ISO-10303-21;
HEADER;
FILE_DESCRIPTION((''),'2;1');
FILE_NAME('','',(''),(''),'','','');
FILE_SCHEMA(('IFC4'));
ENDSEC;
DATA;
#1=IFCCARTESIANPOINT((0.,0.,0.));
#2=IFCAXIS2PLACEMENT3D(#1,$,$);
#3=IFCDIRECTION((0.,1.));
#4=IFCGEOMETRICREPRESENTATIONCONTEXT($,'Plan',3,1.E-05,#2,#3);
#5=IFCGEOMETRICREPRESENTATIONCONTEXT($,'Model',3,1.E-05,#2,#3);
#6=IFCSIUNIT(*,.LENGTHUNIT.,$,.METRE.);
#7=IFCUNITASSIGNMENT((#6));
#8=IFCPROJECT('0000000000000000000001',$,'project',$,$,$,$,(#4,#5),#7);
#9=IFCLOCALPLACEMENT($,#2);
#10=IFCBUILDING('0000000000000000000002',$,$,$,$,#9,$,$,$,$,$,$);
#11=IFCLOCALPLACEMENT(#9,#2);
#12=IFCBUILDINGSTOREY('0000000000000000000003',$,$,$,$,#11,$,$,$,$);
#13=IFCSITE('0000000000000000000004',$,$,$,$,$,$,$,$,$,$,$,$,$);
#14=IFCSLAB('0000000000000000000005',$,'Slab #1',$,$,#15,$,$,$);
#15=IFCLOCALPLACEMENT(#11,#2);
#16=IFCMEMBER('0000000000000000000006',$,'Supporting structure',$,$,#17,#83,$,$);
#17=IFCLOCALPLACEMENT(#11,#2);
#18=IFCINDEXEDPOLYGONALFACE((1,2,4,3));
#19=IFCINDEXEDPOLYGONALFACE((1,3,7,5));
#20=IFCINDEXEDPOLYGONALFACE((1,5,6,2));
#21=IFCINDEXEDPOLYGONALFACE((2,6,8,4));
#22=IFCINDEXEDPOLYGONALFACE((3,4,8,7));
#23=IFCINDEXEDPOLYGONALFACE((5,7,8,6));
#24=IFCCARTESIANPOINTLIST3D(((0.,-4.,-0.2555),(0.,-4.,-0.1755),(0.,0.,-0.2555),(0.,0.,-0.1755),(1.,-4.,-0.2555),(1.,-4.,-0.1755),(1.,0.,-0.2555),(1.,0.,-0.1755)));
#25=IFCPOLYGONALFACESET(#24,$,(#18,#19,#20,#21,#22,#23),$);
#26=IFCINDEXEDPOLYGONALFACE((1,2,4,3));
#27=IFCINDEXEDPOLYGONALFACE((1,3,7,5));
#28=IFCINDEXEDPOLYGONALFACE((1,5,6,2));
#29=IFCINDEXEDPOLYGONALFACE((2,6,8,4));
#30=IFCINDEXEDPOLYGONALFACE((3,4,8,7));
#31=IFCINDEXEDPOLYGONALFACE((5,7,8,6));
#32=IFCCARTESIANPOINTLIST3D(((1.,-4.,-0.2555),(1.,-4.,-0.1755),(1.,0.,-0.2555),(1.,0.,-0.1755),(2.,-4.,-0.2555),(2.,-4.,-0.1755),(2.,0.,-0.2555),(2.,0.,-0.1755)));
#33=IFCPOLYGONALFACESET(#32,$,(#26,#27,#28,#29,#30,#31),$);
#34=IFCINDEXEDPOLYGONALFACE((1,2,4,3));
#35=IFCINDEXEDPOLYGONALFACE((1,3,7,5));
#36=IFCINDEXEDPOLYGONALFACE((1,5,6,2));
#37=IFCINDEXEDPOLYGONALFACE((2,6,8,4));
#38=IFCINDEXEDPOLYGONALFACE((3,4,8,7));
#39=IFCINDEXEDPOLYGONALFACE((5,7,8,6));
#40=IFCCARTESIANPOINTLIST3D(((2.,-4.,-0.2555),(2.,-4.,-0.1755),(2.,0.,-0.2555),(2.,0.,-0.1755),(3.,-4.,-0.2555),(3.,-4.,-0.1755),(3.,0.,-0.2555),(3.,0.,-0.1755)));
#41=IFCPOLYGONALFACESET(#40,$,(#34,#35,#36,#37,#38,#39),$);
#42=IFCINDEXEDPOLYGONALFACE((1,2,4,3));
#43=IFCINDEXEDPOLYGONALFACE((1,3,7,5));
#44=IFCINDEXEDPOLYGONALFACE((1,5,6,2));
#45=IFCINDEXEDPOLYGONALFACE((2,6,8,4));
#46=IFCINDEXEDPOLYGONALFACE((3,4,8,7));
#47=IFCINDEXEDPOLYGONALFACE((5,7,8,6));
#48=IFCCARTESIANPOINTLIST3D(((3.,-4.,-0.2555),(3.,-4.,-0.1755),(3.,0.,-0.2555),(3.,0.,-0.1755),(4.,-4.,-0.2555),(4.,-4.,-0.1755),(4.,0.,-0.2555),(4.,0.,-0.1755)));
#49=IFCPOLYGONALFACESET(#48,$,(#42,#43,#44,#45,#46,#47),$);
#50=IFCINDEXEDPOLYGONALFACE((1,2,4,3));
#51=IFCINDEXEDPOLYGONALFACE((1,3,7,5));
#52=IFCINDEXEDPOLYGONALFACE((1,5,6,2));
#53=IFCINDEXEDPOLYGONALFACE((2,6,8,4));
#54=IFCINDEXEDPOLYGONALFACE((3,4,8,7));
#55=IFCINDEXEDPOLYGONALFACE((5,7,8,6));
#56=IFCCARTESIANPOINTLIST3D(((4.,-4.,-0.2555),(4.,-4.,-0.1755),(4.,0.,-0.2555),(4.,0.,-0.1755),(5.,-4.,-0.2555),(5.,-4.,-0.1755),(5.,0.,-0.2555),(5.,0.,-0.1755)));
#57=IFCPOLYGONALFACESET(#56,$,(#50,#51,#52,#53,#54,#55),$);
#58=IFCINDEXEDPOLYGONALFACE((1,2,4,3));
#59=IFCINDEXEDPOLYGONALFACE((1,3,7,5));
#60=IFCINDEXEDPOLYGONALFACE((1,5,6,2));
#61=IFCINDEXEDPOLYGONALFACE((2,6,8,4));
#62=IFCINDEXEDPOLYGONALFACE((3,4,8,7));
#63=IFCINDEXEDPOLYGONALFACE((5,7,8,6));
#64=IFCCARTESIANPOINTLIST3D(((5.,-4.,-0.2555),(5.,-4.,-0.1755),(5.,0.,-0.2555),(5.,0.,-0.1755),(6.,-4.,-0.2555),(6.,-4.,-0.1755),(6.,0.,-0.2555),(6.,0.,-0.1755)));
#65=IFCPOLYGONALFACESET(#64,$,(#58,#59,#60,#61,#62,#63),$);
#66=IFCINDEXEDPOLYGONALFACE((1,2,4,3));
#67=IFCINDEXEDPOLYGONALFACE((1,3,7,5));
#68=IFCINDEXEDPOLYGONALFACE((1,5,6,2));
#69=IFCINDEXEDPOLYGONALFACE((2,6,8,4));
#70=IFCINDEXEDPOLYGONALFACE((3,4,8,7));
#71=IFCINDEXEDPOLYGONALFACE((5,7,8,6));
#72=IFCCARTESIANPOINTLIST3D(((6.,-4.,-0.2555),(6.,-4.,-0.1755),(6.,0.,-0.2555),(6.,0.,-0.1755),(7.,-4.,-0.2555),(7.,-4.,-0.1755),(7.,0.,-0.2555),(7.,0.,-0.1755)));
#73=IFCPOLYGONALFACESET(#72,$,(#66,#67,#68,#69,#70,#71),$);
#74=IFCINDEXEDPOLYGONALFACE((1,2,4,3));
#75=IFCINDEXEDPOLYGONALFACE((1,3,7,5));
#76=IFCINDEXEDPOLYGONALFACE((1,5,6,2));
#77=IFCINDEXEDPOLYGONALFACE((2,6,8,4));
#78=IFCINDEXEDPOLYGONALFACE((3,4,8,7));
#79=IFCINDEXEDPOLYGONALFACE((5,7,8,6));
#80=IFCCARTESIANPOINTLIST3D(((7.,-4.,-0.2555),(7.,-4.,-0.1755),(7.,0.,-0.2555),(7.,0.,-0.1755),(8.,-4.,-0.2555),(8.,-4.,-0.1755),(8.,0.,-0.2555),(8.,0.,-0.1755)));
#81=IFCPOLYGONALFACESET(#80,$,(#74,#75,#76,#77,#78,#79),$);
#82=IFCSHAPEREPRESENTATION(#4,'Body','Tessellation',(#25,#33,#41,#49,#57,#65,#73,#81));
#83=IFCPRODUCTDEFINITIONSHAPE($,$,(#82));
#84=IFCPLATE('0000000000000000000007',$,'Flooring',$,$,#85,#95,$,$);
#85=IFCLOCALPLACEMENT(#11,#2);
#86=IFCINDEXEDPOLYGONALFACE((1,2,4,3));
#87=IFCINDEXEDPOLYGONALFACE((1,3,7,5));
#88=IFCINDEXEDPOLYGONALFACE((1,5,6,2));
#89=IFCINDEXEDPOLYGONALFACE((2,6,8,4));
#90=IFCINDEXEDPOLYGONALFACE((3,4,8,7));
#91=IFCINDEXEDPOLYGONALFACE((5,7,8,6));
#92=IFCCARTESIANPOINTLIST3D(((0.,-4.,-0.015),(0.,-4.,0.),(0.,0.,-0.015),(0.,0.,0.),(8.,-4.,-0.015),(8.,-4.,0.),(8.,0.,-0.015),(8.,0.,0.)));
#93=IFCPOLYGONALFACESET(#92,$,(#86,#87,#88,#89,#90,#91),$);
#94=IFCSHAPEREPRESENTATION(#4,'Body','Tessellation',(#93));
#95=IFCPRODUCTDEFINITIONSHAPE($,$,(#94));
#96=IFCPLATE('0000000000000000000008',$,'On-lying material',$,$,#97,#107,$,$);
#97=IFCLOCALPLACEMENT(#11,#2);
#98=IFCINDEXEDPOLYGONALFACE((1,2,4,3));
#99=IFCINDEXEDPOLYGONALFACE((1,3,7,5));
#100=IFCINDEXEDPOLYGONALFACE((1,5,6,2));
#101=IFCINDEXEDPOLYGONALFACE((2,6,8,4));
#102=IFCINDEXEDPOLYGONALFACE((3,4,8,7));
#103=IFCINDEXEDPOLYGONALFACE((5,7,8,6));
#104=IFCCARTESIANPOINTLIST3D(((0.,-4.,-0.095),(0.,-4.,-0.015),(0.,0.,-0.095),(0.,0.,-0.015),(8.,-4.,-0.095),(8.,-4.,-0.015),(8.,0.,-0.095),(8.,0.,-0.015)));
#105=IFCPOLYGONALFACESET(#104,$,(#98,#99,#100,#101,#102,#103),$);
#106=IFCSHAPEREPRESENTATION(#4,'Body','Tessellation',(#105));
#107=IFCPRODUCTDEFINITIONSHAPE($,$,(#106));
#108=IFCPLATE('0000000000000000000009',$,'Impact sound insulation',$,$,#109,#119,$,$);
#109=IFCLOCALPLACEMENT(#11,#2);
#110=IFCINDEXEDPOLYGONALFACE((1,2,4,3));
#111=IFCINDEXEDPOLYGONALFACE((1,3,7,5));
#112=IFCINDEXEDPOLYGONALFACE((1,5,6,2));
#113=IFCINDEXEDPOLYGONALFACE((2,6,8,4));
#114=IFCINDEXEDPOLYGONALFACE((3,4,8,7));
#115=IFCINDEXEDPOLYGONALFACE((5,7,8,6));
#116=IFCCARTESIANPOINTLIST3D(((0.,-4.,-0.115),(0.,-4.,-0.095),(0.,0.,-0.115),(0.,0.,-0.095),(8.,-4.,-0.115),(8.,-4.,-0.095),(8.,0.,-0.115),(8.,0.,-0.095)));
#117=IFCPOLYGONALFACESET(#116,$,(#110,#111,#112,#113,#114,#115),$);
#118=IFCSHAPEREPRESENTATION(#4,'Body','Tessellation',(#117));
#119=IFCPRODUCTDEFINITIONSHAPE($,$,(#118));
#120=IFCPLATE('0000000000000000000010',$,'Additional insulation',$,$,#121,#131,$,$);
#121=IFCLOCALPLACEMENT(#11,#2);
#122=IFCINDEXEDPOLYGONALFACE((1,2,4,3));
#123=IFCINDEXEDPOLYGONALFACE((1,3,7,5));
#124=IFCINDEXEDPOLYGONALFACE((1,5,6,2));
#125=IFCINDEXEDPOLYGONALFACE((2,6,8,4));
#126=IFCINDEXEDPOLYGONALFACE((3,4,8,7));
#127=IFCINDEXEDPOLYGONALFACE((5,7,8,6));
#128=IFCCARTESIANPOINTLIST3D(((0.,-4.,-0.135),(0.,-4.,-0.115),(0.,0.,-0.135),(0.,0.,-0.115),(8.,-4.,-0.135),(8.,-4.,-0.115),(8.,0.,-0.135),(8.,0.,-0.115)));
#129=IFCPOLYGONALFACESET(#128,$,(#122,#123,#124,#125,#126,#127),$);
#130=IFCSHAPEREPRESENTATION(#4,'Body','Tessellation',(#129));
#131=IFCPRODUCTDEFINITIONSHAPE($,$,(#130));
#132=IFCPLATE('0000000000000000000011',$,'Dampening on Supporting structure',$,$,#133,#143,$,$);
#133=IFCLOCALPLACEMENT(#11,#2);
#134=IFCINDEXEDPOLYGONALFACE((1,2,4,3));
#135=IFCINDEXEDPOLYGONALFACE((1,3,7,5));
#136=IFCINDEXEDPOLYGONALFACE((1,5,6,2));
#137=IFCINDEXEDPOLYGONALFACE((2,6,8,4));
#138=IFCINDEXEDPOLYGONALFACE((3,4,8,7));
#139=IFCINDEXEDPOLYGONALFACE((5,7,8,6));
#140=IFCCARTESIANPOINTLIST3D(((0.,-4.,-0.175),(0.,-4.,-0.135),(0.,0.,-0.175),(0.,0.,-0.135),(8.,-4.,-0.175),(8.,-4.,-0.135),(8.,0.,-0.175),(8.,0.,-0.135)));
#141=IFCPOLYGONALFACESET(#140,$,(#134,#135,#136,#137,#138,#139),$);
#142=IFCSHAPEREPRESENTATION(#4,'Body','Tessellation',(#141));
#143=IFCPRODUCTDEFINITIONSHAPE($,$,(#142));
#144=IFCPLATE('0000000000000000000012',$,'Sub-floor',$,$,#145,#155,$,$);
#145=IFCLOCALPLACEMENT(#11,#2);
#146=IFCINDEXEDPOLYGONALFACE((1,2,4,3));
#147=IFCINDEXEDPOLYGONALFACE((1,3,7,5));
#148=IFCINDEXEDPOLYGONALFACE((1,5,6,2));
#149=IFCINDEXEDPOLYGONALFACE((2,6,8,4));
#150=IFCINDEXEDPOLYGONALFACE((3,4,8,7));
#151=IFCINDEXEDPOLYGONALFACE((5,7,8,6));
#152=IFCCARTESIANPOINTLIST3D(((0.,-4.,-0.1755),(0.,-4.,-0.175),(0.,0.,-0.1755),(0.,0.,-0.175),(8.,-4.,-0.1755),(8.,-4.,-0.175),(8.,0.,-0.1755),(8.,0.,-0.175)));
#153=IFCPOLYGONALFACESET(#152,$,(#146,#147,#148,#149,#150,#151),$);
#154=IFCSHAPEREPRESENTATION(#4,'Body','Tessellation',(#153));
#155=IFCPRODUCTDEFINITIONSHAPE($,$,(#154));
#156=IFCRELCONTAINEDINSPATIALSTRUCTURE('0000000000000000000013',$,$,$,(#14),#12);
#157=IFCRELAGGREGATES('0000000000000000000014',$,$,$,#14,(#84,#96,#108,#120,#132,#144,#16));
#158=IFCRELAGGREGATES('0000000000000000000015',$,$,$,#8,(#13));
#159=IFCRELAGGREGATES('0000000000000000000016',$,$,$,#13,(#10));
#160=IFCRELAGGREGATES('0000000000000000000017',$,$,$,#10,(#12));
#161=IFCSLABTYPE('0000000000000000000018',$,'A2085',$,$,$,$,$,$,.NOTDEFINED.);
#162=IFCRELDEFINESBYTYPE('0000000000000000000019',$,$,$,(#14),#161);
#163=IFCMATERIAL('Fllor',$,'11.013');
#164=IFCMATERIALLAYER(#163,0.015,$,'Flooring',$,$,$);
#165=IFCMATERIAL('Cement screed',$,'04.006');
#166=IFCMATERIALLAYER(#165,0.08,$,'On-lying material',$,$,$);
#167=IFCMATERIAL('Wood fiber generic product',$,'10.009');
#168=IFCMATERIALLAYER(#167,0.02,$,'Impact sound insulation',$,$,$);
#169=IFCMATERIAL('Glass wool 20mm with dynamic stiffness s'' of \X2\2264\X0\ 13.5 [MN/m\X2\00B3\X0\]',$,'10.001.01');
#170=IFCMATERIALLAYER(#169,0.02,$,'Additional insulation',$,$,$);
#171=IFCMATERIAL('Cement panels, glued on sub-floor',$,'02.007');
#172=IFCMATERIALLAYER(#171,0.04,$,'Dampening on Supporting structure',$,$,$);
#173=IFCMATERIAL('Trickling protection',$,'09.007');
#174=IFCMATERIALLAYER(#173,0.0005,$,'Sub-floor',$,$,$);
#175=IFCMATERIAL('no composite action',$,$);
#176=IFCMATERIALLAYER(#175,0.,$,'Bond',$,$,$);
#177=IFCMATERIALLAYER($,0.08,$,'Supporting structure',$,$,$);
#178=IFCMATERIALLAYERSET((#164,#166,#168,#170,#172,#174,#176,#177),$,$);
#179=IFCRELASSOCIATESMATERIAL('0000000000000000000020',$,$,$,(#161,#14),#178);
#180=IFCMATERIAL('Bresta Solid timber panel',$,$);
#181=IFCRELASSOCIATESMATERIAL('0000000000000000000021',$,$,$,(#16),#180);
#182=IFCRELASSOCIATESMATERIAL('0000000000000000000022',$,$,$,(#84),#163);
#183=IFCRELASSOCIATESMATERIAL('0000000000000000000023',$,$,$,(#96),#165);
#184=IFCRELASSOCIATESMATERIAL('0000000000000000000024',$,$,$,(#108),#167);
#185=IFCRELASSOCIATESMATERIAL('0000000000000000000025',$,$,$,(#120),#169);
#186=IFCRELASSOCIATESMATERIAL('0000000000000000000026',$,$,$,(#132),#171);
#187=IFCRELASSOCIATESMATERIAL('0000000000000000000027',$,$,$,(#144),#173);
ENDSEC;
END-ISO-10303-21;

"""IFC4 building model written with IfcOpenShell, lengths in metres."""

from ifc_helpers import new_model, si_unit, direction, frame, frame_2d, origin, origin_with_axes, place, context, project, spatial, rectangle, extrude, material, layer, layer_set, type_object, element, aggregate, save


model = new_model("IFC4")

# Units and contexts
plan_context = context("Plan", 3, precision=1e-05, world=origin(), true_north=direction((0.0, 1.0)))
model_context = context("Model", 3, precision=1e-05, world=origin(), true_north=direction((0.0, 1.0)))
ifc_project = project(units=[si_unit("LENGTHUNIT", "METRE")], contexts=[plan_context, model_context])

# Site, building, storey
site = spatial("IfcSite", under=ifc_project)
building_placement = place(None, origin())
building = spatial("IfcBuilding", under=site, at=building_placement)
storey_placement = place(building_placement, origin())
storey = spatial("IfcBuildingStorey", under=building, at=storey_placement)

# Slab, member, plates
ifc_material_1 = material(Name="Fllor", Category="11.013")
ifc_layer_1 = layer(ifc_material_1, 0.015, Name="Flooring")
ifc_material_2 = material(Name="Cement screed", Category="04.006")
ifc_layer_2 = layer(ifc_material_2, 0.08, Name="On-lying material")
ifc_material_3 = material(Name="Wood fiber generic product", Category="10.009")
ifc_layer_3 = layer(ifc_material_3, 0.02, Name="Impact sound insulation")
ifc_material_4 = material(Name="Glass wool 20mm with dynamic stiffness s' of ≤ 13.5 [MN/m³]", Category="10.001.01")
ifc_layer_4 = layer(ifc_material_4, 0.02, Name="Additional insulation")
ifc_material_5 = material(Name="Cement panels, glued on sub-floor", Category="02.007")
ifc_layer_5 = layer(ifc_material_5, 0.04, Name="Dampening on Supporting structure")
ifc_material_6 = material(Name="Trickling protection", Category="09.007")
ifc_layer_6 = layer(ifc_material_6, 0.0005, Name="Sub-floor")
ifc_material_7 = material(Name="no composite action")
ifc_layer_7 = layer(ifc_material_7, 0.0, Name="Bond")
ifc_layer_8 = layer(None, 0.08, Name="Supporting structure")
ifc_layer_set = layer_set([ifc_layer_1, ifc_layer_2, ifc_layer_3, ifc_layer_4, ifc_layer_5, ifc_layer_6, ifc_layer_7, ifc_layer_8])
slab_type = type_object("IfcSlabType", Name="A2085", PredefinedType="NOTDEFINED", material=ifc_layer_set)
slab_placement = place(None, frame((0.0, 0.0, 0.0), z_axis=(0.0, 0.0, -1.0), x_axis=(1.0, 0.0, 0.0)))
slab = element("IfcSlab", 1, at=slab_placement, inside=storey, type_object=slab_type, material=ifc_layer_set, Name="Slab #1")
ifc_material_8 = material(Name="Bresta Solid timber panel")
member_placement = place(slab_placement, origin())
member = element("IfcMember", 2, at=member_placement, material=ifc_material_8, Name="Supporting structure", context=plan_context, shape_type="SweptSolid", body=[
    extrude(rectangle(XDim=1.0, YDim=0.08, at=frame_2d((0.5, 0.04), x_axis=(1.0, 0.0))), frame((0.0, 4.0, 0.1755), z_axis=(0.0, -1.0, 0.0), x_axis=(1.0, 0.0, 0.0)), (0.0, 0.0, 1.0), 4.0),
    extrude(rectangle(XDim=1.0, YDim=0.08, at=frame_2d((0.5, 0.04), x_axis=(1.0, 0.0))), frame((1.0, 4.0, 0.1755), z_axis=(0.0, -1.0, 0.0), x_axis=(1.0, 0.0, 0.0)), (0.0, 0.0, 1.0), 4.0),
    extrude(rectangle(XDim=1.0, YDim=0.08, at=frame_2d((0.5, 0.04), x_axis=(1.0, 0.0))), frame((2.0, 4.0, 0.1755), z_axis=(0.0, -1.0, 0.0), x_axis=(1.0, 0.0, 0.0)), (0.0, 0.0, 1.0), 4.0),
    extrude(rectangle(XDim=1.0, YDim=0.08, at=frame_2d((0.5, 0.04), x_axis=(1.0, 0.0))), frame((3.0, 4.0, 0.1755), z_axis=(0.0, -1.0, 0.0), x_axis=(1.0, 0.0, 0.0)), (0.0, 0.0, 1.0), 4.0),
    extrude(rectangle(XDim=1.0, YDim=0.08, at=frame_2d((0.5, 0.04), x_axis=(1.0, 0.0))), frame((4.0, 4.0, 0.1755), z_axis=(0.0, -1.0, 0.0), x_axis=(1.0, 0.0, 0.0)), (0.0, 0.0, 1.0), 4.0),
    extrude(rectangle(XDim=1.0, YDim=0.08, at=frame_2d((0.5, 0.04), x_axis=(1.0, 0.0))), frame((5.0, 4.0, 0.1755), z_axis=(0.0, -1.0, 0.0), x_axis=(1.0, 0.0, 0.0)), (0.0, 0.0, 1.0), 4.0),
    extrude(rectangle(XDim=1.0, YDim=0.08, at=frame_2d((0.5, 0.04), x_axis=(1.0, 0.0))), frame((6.0, 4.0, 0.1755), z_axis=(0.0, -1.0, 0.0), x_axis=(1.0, 0.0, 0.0)), (0.0, 0.0, 1.0), 4.0),
    extrude(rectangle(XDim=1.0, YDim=0.08, at=frame_2d((0.5, 0.04), x_axis=(1.0, 0.0))), frame((7.0, 4.0, 0.1755), z_axis=(0.0, -1.0, 0.0), x_axis=(1.0, 0.0, 0.0)), (0.0, 0.0, 1.0), 4.0),
])
plate_1_placement = place(slab_placement, origin())
plate_1 = element("IfcPlate", 3, at=plate_1_placement, material=ifc_material_1, Name="Flooring", context=plan_context, shape_type="SweptSolid", body=[
    extrude(rectangle(XDim=8.0, YDim=4.0, at=frame_2d((4.0, 2.0), x_axis=(1.0, 0.0))), origin_with_axes(), (0.0, 0.0, 1.0), 0.015),
])
plate_2_placement = place(slab_placement, origin())
plate_2 = element("IfcPlate", 4, at=plate_2_placement, material=ifc_material_2, Name="On-lying material", context=plan_context, shape_type="SweptSolid", body=[
    extrude(rectangle(XDim=8.0, YDim=4.0, at=frame_2d((4.0, 2.0), x_axis=(1.0, 0.0))), frame((0.0, 0.0, 0.015), z_axis=(0.0, 0.0, 1.0), x_axis=(1.0, 0.0, 0.0)), (0.0, 0.0, 1.0), 0.08),
])
plate_3_placement = place(slab_placement, origin())
plate_3 = element("IfcPlate", 5, at=plate_3_placement, material=ifc_material_3, Name="Impact sound insulation", context=plan_context, shape_type="SweptSolid", body=[
    extrude(rectangle(XDim=8.0, YDim=4.0, at=frame_2d((4.0, 2.0), x_axis=(1.0, 0.0))), frame((0.0, 0.0, 0.095), z_axis=(0.0, 0.0, 1.0), x_axis=(1.0, 0.0, 0.0)), (0.0, 0.0, 1.0), 0.02),
])
plate_4_placement = place(slab_placement, origin())
plate_4 = element("IfcPlate", 6, at=plate_4_placement, material=ifc_material_4, Name="Additional insulation", context=plan_context, shape_type="SweptSolid", body=[
    extrude(rectangle(XDim=8.0, YDim=4.0, at=frame_2d((4.0, 2.0), x_axis=(1.0, 0.0))), frame((0.0, 0.0, 0.115), z_axis=(0.0, 0.0, 1.0), x_axis=(1.0, 0.0, 0.0)), (0.0, 0.0, 1.0), 0.02),
])
plate_5_placement = place(slab_placement, origin())
plate_5 = element("IfcPlate", 7, at=plate_5_placement, material=ifc_material_5, Name="Dampening on Supporting structure", context=plan_context, shape_type="SweptSolid", body=[
    extrude(rectangle(XDim=8.0, YDim=4.0, at=frame_2d((4.0, 2.0), x_axis=(1.0, 0.0))), frame((0.0, 0.0, 0.135), z_axis=(0.0, 0.0, 1.0), x_axis=(1.0, 0.0, 0.0)), (0.0, 0.0, 1.0), 0.04),
])
plate_6_placement = place(slab_placement, origin())
plate_6 = element("IfcPlate", 8, at=plate_6_placement, material=ifc_material_6, Name="Sub-floor", context=plan_context, shape_type="SweptSolid", body=[
    extrude(rectangle(XDim=8.0, YDim=4.0, at=frame_2d((4.0, 2.0), x_axis=(1.0, 0.0))), frame((0.0, 0.0, 0.175), z_axis=(0.0, 0.0, 1.0), x_axis=(1.0, 0.0, 0.0)), (0.0, 0.0, 1.0), 0.0005),
])
aggregate(slab, [plate_1, plate_2, plate_3, plate_4, plate_5, plate_6, member])

save(model, "model.ifc")
